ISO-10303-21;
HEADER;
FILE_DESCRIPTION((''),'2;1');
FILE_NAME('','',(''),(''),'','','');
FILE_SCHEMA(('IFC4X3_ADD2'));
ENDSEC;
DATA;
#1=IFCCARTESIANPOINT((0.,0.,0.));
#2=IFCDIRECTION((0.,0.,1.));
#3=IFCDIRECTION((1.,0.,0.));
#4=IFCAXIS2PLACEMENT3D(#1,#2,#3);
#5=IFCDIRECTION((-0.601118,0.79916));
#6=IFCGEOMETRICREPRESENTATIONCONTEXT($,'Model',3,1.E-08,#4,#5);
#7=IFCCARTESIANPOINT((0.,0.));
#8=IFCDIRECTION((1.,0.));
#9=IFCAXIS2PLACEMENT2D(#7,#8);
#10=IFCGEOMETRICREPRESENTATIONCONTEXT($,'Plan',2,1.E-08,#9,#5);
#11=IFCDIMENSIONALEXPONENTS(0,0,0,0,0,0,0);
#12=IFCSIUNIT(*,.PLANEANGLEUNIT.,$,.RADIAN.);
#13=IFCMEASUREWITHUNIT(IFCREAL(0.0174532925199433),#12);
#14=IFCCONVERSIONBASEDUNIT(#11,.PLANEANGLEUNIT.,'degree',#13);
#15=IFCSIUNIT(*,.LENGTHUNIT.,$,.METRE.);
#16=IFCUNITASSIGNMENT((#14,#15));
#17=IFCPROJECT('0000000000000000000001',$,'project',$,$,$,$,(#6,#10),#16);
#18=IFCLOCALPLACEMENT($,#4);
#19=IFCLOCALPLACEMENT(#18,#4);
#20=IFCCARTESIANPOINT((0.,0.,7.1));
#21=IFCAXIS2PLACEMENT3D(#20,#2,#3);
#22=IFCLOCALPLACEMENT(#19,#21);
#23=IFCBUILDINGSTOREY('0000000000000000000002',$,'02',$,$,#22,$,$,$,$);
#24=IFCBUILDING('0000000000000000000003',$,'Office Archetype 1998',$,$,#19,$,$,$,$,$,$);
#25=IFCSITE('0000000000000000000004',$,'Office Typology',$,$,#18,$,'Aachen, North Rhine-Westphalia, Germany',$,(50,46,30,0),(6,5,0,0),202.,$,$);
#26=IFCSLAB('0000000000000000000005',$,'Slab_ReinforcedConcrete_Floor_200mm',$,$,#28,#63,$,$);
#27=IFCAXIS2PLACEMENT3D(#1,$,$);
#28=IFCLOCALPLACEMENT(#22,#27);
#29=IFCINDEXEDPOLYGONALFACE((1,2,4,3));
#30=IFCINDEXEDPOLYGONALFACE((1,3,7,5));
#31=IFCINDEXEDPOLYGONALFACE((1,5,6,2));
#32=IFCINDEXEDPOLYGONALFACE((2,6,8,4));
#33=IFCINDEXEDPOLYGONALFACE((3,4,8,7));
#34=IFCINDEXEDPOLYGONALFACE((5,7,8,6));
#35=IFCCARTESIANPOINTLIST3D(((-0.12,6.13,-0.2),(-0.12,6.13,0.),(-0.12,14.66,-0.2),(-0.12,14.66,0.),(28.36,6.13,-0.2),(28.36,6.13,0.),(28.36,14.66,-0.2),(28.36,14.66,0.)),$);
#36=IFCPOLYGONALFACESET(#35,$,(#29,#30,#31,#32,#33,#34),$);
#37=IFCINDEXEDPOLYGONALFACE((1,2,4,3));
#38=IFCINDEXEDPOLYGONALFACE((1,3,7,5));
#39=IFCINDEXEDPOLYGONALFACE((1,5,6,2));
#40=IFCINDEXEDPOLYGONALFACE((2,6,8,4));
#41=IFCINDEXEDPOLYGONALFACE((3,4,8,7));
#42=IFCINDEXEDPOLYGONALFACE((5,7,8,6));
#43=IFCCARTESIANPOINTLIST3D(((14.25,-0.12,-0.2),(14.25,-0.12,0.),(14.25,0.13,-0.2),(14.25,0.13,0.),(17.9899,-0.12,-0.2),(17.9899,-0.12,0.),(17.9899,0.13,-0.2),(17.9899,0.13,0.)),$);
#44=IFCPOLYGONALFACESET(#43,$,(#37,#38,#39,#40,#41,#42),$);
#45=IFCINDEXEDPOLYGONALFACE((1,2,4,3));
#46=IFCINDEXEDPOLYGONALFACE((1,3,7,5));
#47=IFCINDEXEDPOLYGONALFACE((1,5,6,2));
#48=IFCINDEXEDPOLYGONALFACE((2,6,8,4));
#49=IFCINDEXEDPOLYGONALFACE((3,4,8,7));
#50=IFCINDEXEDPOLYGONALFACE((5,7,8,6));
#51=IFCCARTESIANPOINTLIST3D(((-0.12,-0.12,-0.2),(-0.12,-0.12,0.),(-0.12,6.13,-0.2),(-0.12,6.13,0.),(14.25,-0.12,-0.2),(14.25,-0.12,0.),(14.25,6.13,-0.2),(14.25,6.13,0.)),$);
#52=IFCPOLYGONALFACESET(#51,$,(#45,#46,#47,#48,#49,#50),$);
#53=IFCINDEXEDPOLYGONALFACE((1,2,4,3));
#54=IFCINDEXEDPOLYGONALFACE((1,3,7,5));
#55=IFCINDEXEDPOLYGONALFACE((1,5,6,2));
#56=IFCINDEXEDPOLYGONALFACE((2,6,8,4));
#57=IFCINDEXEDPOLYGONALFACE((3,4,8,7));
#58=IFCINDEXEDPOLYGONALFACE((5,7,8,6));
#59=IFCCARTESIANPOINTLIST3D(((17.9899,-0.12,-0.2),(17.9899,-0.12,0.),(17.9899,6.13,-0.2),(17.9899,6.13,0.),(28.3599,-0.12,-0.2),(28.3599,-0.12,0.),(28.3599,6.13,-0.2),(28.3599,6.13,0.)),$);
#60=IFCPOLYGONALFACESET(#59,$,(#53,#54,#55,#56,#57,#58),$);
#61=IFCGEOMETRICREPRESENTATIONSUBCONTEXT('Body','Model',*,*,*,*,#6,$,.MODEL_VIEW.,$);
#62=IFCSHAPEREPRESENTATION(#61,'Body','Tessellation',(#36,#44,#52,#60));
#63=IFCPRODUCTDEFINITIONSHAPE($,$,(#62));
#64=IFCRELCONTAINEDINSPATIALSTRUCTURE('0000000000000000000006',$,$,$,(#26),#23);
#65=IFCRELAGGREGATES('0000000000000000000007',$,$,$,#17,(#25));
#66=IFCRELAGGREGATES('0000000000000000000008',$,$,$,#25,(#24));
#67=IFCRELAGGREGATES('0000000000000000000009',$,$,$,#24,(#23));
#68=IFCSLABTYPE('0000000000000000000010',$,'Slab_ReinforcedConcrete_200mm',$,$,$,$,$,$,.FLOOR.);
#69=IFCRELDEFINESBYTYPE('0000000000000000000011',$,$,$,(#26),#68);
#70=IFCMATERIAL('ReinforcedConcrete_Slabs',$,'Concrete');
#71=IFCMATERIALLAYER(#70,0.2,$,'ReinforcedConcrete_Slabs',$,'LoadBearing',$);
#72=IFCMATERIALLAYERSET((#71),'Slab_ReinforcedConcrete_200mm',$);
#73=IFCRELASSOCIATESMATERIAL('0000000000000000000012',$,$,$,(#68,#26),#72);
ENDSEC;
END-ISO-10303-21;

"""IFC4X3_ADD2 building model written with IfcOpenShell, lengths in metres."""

from ifc_helpers import new_model, entity, si_unit, converted_unit, direction, frame, origin_with_axes, origin_2d_with_axis, place, context, subcontext, project, spatial, indexed_curve, outline, extrude, material, layer, layer_set, layer_usage, type_object, element, save


model = new_model("IFC4X3_ADD2")

# Units and contexts
model_context = context("Model", 3, precision=1e-08, world=origin_with_axes(), true_north=direction((-0.601118, 0.79916)))
plan_context = context("Plan", 2, precision=1e-08, world=origin_2d_with_axis(), true_north=direction((-0.601118, 0.79916)))
body_context = subcontext(model_context, "Body", "Model", "MODEL_VIEW")
ifc_project = project(units=[converted_unit("PLANEANGLEUNIT", "degree", entity("IfcReal", 0.0174532925199433), si_unit("PLANEANGLEUNIT", "RADIAN"), dimensions=[0, 0, 0, 0, 0, 0, 0]), si_unit("LENGTHUNIT", "METRE")], contexts=[model_context, plan_context])

# Site, building, storey
site_placement = place(None, origin_with_axes())
site = spatial("IfcSite", under=ifc_project, at=site_placement, Name="Office Typology", LongName="Aachen, North Rhine-Westphalia, Germany", RefLatitude=(50, 46, 30, 0), RefLongitude=(6, 5, 0, 0), RefElevation=202.0)
building_placement = place(site_placement, origin_with_axes())
building = spatial("IfcBuilding", under=site, at=building_placement, Name="Office Archetype 1998")
storey_placement = place(building_placement, frame((0.0, 0.0, 7.1), z_axis=(0.0, 0.0, 1.0), x_axis=(1.0, 0.0, 0.0)))
storey = spatial("IfcBuildingStorey", under=building, at=storey_placement, Name="02")

# Slab
ifc_material_1 = material(Name="ReinforcedConcrete_Slabs", Category="Concrete")
ifc_layer_1 = layer(ifc_material_1, 0.2, Name="ReinforcedConcrete_Slabs", Category="LoadBearing")
ifc_layer_set_1 = layer_set([ifc_layer_1], Name="Slab_ReinforcedConcrete_200mm")
slab_type_1 = type_object("IfcSlabType", Name="Slab_ReinforcedConcrete_200mm", PredefinedType="FLOOR", material=ifc_layer_set_1)
ifc_layer_usage_1 = layer_usage(ifc_layer_set_1, "AXIS3", "POSITIVE", 0.0)
slab_1_placement = place(storey_placement, frame((17.9899, 6.13, 0.0), z_axis=(0.0, 0.0, 1.0), x_axis=(1.0, 0.0, 0.0)))
element("IfcSlab", 1, at=slab_1_placement, inside=storey, type_object=slab_type_1, material=ifc_layer_usage_1, Name="Slab_ReinforcedConcrete_Floor_200mm", context=body_context, shape_type="SweptSolid", body=[
    extrude(outline(indexed_curve([(0.0, 0.0), (28.48, 0.0), (28.48, -8.53), (0.0, -8.53), (0.0, 0.0)])), frame((-18.1099, 8.53, -0.2), z_axis=(0.0, 0.0, 1.0), x_axis=(1.0, 0.0, 0.0)), (0.0, 0.0, 1.0), 0.2),
    extrude(outline(indexed_curve([(0.0, 0.0), (3.7399, 0.0), (3.7399, 0.25), (0.0, 0.25), (0.0, 0.0)])), frame((-3.7399, -6.25, -0.2), z_axis=(0.0, 0.0, 1.0), x_axis=(1.0, 0.0, 0.0)), (0.0, 0.0, 1.0), 0.2),
    extrude(outline(indexed_curve([(0.0, 0.0), (14.37, 0.0), (14.37, -6.25), (0.0, -6.25), (0.0, 0.0)])), frame((-18.1099, 0.0, -0.2), z_axis=(0.0, 0.0, 1.0), x_axis=(1.0, 0.0, 0.0)), (0.0, 0.0, 1.0), 0.2),
    extrude(outline(indexed_curve([(0.0, 0.0), (0.0, -6.25), (10.37, -6.25), (10.37, 0.0), (0.0, 0.0)])), frame((0.0, 0.0, -0.2), z_axis=(0.0, 0.0, 1.0), x_axis=(1.0, 0.0, 0.0)), (0.0, 0.0, 1.0), 0.2),
])

save(model, "model.ifc")
